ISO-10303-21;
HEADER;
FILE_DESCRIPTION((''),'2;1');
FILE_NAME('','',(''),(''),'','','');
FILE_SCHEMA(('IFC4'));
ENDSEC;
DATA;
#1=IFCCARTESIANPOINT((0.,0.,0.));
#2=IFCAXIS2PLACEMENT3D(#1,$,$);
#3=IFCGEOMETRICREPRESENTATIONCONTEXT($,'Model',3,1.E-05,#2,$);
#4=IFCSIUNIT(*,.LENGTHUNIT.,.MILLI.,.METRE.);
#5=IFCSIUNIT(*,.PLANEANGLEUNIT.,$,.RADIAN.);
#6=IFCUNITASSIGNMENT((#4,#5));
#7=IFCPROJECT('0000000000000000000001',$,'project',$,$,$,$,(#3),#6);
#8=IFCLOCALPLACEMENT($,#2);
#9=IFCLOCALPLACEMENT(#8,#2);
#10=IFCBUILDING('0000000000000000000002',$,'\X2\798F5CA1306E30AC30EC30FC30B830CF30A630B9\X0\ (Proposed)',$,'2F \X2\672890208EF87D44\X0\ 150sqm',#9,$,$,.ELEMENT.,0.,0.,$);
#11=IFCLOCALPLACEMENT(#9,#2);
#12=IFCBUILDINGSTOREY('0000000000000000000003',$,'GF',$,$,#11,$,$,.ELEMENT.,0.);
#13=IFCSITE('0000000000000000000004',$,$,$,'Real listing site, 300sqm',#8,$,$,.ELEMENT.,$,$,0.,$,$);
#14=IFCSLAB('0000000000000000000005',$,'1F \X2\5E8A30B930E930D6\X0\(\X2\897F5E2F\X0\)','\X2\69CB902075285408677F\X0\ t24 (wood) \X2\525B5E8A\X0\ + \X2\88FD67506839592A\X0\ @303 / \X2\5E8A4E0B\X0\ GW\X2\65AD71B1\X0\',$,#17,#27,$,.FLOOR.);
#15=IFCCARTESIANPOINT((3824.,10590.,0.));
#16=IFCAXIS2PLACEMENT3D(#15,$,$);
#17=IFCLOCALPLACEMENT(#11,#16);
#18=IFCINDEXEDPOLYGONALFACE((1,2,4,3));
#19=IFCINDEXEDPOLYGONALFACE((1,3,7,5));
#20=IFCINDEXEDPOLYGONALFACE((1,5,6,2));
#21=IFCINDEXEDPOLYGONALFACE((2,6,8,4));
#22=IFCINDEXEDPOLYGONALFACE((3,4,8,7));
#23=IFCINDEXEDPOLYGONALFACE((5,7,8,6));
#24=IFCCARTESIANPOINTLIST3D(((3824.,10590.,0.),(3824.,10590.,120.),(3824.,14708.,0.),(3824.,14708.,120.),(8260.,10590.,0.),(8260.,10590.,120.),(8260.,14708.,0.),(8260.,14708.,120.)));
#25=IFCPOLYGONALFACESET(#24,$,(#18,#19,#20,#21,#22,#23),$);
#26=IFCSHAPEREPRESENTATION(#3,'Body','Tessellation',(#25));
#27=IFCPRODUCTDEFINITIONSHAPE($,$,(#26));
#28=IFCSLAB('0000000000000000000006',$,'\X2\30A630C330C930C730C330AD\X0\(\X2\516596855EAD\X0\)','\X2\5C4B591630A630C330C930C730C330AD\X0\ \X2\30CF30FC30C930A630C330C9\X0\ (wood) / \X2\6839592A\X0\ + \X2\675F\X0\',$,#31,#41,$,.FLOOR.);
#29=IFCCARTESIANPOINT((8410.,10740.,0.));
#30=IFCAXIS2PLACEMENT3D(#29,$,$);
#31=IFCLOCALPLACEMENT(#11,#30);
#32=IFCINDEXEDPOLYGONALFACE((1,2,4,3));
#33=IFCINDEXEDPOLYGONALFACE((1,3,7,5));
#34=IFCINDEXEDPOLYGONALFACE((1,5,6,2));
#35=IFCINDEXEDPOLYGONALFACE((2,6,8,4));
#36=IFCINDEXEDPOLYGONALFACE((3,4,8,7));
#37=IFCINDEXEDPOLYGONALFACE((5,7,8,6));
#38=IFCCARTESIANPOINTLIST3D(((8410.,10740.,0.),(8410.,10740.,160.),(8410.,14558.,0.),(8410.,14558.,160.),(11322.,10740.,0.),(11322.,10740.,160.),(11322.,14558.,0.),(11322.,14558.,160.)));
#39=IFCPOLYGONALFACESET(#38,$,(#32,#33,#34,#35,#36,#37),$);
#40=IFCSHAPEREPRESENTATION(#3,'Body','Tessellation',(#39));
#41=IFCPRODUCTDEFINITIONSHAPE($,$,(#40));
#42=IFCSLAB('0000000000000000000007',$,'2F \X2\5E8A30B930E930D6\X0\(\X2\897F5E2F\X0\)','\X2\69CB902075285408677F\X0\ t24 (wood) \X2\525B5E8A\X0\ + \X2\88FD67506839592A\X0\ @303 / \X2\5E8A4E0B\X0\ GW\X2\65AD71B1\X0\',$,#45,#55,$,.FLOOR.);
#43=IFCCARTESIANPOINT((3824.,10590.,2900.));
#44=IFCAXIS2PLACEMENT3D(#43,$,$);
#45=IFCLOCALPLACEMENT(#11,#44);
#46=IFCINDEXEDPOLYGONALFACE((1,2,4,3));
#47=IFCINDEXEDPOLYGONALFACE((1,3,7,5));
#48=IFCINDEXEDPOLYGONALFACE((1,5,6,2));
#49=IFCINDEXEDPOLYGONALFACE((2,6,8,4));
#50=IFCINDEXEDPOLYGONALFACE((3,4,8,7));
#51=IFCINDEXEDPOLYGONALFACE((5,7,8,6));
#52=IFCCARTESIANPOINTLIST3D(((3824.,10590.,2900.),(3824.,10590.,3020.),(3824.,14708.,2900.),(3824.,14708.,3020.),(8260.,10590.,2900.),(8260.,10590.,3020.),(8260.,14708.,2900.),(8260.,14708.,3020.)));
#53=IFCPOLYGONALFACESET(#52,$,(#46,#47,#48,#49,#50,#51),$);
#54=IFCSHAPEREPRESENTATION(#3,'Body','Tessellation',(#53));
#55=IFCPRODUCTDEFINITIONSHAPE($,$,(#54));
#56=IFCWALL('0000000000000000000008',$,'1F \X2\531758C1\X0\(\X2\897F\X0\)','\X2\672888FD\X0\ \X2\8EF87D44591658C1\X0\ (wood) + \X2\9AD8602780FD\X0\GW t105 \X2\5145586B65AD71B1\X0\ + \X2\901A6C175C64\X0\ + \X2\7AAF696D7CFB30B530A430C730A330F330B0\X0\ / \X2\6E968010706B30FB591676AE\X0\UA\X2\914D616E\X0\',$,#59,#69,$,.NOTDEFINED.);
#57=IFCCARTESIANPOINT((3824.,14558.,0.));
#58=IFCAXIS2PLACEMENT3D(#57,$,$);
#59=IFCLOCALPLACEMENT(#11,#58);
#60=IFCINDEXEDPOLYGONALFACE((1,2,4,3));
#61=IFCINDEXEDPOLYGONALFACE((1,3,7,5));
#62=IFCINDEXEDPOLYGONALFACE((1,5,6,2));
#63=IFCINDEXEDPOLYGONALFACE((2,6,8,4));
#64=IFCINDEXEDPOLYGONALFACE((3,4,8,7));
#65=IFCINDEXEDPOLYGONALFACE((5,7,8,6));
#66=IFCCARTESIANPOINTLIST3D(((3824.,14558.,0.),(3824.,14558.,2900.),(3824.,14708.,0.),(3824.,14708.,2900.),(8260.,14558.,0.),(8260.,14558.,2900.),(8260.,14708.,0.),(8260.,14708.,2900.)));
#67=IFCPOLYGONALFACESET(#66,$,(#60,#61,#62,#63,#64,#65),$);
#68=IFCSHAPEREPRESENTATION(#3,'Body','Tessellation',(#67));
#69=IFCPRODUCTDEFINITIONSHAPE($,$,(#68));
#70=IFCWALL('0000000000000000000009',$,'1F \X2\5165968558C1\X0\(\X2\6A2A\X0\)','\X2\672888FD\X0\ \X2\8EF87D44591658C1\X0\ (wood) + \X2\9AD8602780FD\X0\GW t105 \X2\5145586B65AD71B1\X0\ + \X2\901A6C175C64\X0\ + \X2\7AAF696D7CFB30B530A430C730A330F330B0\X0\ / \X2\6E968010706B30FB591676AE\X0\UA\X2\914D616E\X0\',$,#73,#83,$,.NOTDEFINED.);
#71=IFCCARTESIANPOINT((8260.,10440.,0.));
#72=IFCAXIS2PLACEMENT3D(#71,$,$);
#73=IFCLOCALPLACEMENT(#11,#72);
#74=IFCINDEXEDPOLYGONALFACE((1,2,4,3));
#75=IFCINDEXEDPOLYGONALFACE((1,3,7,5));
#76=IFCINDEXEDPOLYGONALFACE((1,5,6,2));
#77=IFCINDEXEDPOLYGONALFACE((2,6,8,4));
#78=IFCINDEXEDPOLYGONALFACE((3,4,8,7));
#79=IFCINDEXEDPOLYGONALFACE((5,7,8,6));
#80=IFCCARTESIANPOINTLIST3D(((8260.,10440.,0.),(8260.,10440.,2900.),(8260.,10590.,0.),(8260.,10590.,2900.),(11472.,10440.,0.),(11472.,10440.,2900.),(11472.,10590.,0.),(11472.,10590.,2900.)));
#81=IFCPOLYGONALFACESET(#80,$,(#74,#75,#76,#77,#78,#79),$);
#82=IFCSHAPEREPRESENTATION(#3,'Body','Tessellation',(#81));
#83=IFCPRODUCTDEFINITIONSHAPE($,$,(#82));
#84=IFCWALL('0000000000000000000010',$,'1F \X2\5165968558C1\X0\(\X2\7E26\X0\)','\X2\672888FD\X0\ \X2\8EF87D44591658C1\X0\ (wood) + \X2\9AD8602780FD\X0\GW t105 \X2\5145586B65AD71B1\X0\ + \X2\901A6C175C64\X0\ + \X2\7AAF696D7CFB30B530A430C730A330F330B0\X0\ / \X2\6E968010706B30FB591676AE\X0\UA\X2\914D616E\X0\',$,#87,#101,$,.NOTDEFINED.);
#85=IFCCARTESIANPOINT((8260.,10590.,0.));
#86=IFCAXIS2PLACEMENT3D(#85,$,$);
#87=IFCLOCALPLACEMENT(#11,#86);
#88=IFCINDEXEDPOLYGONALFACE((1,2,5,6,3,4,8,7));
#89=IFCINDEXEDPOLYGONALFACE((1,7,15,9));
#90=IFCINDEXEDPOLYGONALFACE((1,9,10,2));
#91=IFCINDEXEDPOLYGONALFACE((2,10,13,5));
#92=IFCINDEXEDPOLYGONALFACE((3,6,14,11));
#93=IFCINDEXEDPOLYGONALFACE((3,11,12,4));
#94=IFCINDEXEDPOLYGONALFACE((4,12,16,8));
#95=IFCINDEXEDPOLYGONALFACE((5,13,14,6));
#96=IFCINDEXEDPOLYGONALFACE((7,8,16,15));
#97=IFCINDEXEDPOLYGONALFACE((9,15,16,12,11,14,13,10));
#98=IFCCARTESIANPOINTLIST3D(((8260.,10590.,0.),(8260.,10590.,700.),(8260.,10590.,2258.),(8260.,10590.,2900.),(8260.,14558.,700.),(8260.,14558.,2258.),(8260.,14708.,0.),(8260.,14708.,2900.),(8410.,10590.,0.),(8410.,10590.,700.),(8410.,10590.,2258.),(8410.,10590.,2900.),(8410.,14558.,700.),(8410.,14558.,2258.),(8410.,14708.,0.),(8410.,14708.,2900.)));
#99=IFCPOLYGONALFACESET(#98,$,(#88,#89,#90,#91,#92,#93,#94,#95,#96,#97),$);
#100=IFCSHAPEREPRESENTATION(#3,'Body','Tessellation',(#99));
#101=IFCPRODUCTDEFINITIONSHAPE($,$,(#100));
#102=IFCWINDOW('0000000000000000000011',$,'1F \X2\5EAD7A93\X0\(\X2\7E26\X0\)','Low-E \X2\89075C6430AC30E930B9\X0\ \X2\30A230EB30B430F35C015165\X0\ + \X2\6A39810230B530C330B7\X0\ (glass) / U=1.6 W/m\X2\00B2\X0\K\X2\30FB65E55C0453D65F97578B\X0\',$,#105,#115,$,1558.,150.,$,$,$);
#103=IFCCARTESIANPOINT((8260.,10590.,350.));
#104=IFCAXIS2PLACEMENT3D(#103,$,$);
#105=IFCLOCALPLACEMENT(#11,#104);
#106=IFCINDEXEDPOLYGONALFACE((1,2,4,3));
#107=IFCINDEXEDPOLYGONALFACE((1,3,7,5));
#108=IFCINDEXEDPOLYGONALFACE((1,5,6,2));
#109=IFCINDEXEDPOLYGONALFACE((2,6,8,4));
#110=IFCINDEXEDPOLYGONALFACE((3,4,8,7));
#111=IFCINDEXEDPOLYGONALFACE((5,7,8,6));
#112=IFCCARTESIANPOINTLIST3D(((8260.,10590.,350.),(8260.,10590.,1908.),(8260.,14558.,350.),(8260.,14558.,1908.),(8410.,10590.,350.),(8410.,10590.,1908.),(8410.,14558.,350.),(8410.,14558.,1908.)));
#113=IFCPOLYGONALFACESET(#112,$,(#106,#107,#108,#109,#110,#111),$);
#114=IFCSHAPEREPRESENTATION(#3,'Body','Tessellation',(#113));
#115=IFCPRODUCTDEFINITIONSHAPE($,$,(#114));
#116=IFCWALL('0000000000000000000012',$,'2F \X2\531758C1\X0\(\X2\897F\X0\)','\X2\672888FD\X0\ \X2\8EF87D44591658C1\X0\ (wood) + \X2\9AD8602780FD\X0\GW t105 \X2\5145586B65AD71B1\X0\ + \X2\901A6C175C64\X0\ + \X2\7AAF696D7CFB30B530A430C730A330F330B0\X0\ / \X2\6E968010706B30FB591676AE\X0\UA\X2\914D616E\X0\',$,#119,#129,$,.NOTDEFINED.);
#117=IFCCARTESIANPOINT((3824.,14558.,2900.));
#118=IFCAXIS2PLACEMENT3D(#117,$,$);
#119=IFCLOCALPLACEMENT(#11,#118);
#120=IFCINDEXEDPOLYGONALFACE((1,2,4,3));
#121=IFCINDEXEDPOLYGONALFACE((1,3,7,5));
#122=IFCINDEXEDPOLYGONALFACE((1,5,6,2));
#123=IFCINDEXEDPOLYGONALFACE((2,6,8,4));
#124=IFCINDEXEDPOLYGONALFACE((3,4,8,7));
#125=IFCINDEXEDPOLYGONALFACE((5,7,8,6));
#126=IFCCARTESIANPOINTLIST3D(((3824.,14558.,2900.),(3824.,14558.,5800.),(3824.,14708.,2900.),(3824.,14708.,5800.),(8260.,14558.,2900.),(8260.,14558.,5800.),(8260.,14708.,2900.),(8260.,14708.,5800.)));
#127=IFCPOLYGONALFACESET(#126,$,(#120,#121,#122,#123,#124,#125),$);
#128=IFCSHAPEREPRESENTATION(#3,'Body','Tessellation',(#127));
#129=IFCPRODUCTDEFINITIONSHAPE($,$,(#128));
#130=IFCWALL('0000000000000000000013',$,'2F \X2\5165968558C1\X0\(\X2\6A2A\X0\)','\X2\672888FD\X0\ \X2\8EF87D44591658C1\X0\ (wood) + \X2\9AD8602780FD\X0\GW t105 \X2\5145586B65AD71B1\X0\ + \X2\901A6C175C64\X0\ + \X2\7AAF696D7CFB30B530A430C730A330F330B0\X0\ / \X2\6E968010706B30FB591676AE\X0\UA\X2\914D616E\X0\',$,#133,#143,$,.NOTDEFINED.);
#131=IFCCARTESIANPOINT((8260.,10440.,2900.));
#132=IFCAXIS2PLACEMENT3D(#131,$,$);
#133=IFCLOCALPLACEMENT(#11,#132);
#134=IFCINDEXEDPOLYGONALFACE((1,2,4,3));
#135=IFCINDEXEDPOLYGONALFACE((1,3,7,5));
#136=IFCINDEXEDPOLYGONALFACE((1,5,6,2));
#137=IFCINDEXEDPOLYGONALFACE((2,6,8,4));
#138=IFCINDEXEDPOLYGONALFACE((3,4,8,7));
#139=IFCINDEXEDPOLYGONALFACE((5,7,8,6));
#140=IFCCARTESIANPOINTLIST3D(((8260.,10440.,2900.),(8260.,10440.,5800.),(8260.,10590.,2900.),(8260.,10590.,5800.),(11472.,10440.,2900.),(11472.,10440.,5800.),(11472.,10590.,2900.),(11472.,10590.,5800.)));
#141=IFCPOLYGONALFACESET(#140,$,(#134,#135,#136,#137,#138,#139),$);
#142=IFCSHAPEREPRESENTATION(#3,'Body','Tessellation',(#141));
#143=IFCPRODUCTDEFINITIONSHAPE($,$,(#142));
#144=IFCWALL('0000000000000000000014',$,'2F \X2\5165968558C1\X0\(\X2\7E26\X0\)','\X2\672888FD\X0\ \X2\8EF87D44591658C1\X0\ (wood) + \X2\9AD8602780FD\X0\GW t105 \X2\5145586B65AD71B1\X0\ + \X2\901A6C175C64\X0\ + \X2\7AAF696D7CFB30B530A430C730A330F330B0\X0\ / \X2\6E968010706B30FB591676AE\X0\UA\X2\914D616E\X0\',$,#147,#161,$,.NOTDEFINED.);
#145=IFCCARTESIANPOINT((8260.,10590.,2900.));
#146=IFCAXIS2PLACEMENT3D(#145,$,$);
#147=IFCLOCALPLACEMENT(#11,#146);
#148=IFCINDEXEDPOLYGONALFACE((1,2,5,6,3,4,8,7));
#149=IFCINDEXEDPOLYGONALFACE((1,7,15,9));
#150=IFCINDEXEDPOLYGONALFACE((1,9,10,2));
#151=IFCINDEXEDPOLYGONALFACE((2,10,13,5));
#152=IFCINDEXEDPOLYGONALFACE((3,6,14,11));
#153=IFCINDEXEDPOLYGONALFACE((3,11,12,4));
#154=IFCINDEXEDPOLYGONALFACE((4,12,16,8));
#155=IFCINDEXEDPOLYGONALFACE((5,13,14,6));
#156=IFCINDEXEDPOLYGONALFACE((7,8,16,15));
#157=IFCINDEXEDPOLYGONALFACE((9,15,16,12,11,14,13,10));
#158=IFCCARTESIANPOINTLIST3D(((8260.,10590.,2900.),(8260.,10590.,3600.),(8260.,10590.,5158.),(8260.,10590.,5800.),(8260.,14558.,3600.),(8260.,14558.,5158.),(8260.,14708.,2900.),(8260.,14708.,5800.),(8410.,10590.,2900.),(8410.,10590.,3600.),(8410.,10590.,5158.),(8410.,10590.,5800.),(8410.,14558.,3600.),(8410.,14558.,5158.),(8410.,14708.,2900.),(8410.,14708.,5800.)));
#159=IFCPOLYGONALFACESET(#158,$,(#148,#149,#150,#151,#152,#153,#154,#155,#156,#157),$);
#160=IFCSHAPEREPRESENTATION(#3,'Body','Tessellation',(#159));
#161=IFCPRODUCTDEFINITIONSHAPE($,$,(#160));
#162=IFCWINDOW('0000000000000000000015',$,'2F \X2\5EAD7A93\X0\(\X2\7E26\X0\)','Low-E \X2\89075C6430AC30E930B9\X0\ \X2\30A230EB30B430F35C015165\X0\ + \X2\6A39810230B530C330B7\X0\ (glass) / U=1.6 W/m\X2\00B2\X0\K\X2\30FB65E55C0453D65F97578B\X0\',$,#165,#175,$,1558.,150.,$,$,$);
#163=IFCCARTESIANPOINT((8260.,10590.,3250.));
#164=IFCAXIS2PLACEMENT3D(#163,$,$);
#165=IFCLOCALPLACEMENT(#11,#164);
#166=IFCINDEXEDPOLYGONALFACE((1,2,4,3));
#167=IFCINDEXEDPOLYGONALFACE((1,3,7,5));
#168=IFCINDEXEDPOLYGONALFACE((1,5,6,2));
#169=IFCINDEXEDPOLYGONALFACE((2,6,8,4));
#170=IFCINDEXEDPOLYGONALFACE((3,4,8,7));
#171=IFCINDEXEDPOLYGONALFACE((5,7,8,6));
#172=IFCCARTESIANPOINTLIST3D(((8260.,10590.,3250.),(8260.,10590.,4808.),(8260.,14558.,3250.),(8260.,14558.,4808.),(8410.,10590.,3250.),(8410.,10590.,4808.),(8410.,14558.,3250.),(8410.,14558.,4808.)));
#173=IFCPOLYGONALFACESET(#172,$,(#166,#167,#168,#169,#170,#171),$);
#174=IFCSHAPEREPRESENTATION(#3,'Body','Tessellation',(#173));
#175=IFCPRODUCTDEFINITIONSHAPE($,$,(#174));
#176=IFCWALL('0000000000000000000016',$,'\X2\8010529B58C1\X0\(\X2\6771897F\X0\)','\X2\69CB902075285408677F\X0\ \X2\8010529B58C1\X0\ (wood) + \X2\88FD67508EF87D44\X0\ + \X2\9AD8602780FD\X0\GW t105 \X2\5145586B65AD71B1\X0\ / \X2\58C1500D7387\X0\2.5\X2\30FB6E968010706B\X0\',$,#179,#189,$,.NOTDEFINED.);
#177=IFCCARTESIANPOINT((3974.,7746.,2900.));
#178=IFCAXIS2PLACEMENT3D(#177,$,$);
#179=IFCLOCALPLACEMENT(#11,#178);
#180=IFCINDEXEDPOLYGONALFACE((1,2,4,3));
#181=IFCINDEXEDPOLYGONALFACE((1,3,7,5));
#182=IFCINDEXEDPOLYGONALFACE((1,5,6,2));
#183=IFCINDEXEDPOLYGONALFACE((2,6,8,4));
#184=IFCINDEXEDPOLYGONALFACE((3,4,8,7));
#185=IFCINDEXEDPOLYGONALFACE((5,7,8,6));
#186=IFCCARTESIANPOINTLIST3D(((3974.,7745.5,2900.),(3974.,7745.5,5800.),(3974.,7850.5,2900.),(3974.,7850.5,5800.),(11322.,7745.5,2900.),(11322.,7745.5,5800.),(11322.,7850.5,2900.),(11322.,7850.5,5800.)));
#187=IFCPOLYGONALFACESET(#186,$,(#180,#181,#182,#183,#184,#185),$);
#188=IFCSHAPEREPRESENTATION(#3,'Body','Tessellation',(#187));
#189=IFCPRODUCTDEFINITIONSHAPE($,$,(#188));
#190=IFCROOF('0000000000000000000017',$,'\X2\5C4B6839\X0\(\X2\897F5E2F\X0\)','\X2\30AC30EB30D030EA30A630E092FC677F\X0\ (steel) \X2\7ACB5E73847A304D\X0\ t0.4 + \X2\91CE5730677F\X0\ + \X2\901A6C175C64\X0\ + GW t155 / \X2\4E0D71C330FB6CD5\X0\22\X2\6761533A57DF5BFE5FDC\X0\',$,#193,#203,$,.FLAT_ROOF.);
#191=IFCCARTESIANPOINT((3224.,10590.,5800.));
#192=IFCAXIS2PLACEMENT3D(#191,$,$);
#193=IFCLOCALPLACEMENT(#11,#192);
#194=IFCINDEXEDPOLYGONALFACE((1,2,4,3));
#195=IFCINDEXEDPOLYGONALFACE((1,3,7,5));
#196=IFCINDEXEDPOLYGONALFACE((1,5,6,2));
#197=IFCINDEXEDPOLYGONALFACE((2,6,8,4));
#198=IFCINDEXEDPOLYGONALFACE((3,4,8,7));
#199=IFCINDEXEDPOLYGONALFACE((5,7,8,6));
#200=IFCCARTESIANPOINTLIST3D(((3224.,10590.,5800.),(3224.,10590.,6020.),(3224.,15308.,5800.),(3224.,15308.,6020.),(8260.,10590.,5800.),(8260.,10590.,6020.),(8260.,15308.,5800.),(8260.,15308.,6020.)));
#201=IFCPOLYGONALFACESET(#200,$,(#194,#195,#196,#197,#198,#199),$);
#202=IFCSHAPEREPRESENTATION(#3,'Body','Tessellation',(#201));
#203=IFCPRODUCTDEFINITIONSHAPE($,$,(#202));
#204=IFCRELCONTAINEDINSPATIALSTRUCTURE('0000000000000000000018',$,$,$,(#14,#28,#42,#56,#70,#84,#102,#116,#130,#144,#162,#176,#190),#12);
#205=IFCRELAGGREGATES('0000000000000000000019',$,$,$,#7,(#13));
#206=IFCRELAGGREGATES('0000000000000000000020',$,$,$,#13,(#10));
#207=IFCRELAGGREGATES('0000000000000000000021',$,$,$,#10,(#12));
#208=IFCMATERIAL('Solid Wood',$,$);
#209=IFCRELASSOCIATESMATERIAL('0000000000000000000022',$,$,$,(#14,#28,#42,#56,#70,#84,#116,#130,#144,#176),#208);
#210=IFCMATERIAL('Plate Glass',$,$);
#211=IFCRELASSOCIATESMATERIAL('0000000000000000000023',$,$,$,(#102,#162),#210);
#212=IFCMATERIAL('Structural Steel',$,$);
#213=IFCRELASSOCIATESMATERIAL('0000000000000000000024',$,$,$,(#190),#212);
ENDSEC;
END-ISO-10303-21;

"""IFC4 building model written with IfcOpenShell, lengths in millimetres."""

from ifc_helpers import new_model, si_unit, frame, frame_2d, origin, place, context, project, spatial, rectangle, extrude, material, element, fill, save


model = new_model("IFC4")

# Units and contexts
model_context = context("Model", 3, precision=1e-05, world=origin())
ifc_project = project(units=[si_unit("LENGTHUNIT", "METRE", prefix="MILLI"), si_unit("PLANEANGLEUNIT", "RADIAN")], contexts=[model_context])

# Site, building, storey
site_placement = place(None, origin())
site = spatial("IfcSite", under=ifc_project, at=site_placement, ObjectType="Real listing site, 300sqm", CompositionType="ELEMENT", RefElevation=0.0)
building_placement = place(site_placement, origin())
building = spatial("IfcBuilding", under=site, at=building_placement, Name="福岡のガレージハウス (Proposed)", ObjectType="2F 木造軸組 150sqm", CompositionType="ELEMENT", ElevationOfRefHeight=0.0, ElevationOfTerrain=0.0)
storey_placement = place(building_placement, origin())
storey = spatial("IfcBuildingStorey", under=building, at=storey_placement, Name="GF", CompositionType="ELEMENT", Elevation=0.0)

# Slabs
ifc_material_1 = material(Name="Solid Wood")
slab_1_placement = place(storey_placement, frame((3824.0, 10590.0, 0.0)))
element("IfcSlab", 1, at=slab_1_placement, inside=storey, material=ifc_material_1, Name="1F 床スラブ(西帯)", Description="構造用合板 t24 (wood) 剛床 + 製材根太 @303 / 床下 GW断熱", PredefinedType="FLOOR", context=model_context, shape_type="SweptSolid", body=[
    extrude(rectangle(XDim=4436.0, YDim=4118.0, at=frame_2d((2218.0, 2059.0))), frame((3824.0, 10590.0, 0.0)), (0.0, 0.0, 1.0), 120.0),
])
slab_2_placement = place(storey_placement, frame((8410.0, 10740.0, 0.0)))
element("IfcSlab", 2, at=slab_2_placement, inside=storey, material=ifc_material_1, Name="ウッドデッキ(入隅庭)", Description="屋外ウッドデッキ ハードウッド (wood) / 根太 + 束", PredefinedType="FLOOR", context=model_context, shape_type="SweptSolid", body=[
    extrude(rectangle(XDim=2912.0, YDim=3818.0, at=frame_2d((1456.0, 1909.0))), frame((8410.0, 10740.0, 0.0)), (0.0, 0.0, 1.0), 160.0),
])
slab_3_placement = place(storey_placement, frame((3824.0, 10590.0, 2900.0)))
element("IfcSlab", 3, at=slab_3_placement, inside=storey, material=ifc_material_1, Name="2F 床スラブ(西帯)", Description="構造用合板 t24 (wood) 剛床 + 製材根太 @303 / 床下 GW断熱", PredefinedType="FLOOR", context=model_context, shape_type="SweptSolid", body=[
    extrude(rectangle(XDim=4436.0, YDim=4118.0, at=frame_2d((2218.0, 2059.0))), frame((3824.0, 10590.0, 2900.0)), (0.0, 0.0, 1.0), 120.0),
])

# Walls
wall_1_placement = place(storey_placement, frame((3824.0, 14558.0, 0.0)))
element("IfcWall", 4, at=wall_1_placement, inside=storey, material=ifc_material_1, Name="1F 北壁(西)", Description="木製 軸組外壁 (wood) + 高性能GW t105 充填断熱 + 通気層 + 窯業系サイディング / 準耐火・外皮UA配慮", PredefinedType="NOTDEFINED", context=model_context, shape_type="SweptSolid", body=[
    extrude(rectangle(XDim=4436.0, YDim=150.0, at=frame_2d((2218.0, 75.0))), frame((3824.0, 14558.0, 0.0)), (0.0, 0.0, 1.0), 2900.0),
])
wall_2_placement = place(storey_placement, frame((8260.0, 10440.0, 0.0)))
element("IfcWall", 5, at=wall_2_placement, inside=storey, material=ifc_material_1, Name="1F 入隅壁(横)", Description="木製 軸組外壁 (wood) + 高性能GW t105 充填断熱 + 通気層 + 窯業系サイディング / 準耐火・外皮UA配慮", PredefinedType="NOTDEFINED", context=model_context, shape_type="SweptSolid", body=[
    extrude(rectangle(XDim=3212.0, YDim=150.0, at=frame_2d((1606.0, 75.0))), frame((8260.0, 10440.0, 0.0)), (0.0, 0.0, 1.0), 2900.0),
])

# Wall, opening, window
wall_3_placement = place(storey_placement, frame((8260.0, 10590.0, 0.0)))
wall_3 = element("IfcWall", 6, at=wall_3_placement, inside=storey, material=ifc_material_1, Name="1F 入隅壁(縦)", Description="木製 軸組外壁 (wood) + 高性能GW t105 充填断熱 + 通気層 + 窯業系サイディング / 準耐火・外皮UA配慮", PredefinedType="NOTDEFINED", context=model_context, shape_type="SweptSolid", body=[
    extrude(rectangle(XDim=150.0, YDim=4118.0, at=frame_2d((75.0, 2059.0))), frame((8260.0, 10590.0, 0.0)), (0.0, 0.0, 1.0), 2900.0),
])
opening_1_placement = place(storey_placement, frame((8260.0, 10590.0, 350.0)))
opening_1 = element("IfcOpeningElement", 7, at=opening_1_placement, cuts=wall_3, PredefinedType="NOTDEFINED", context=model_context, shape_type="SweptSolid", body=[
    extrude(rectangle(XDim=150.0, YDim=3968.0, at=frame_2d((75.0, 1984.0))), frame((8260.0, 10590.0, 350.0)), (0.0, 0.0, 1.0), 1558.0),
])
ifc_material_2 = material(Name="Plate Glass")
window_1_placement = place(storey_placement, frame((8260.0, 10590.0, 350.0)))
window_1 = element("IfcWindow", 8, at=window_1_placement, inside=storey, material=ifc_material_2, Name="1F 庭窓(縦)", Description="Low-E 複層ガラス アルゴン封入 + 樹脂サッシ (glass) / U=1.6 W/m²K・日射取得型", OverallHeight=1558.0, OverallWidth=150.0, context=model_context, shape_type="SweptSolid", body=[
    extrude(rectangle(XDim=150.0, YDim=3968.0, at=frame_2d((75.0, 1984.0))), frame((8260.0, 10590.0, 350.0)), (0.0, 0.0, 1.0), 1558.0),
])
fill(opening_1, window_1)

# Walls
wall_4_placement = place(storey_placement, frame((3824.0, 14558.0, 2900.0)))
element("IfcWall", 9, at=wall_4_placement, inside=storey, material=ifc_material_1, Name="2F 北壁(西)", Description="木製 軸組外壁 (wood) + 高性能GW t105 充填断熱 + 通気層 + 窯業系サイディング / 準耐火・外皮UA配慮", PredefinedType="NOTDEFINED", context=model_context, shape_type="SweptSolid", body=[
    extrude(rectangle(XDim=4436.0, YDim=150.0, at=frame_2d((2218.0, 75.0))), frame((3824.0, 14558.0, 2900.0)), (0.0, 0.0, 1.0), 2900.0),
])
wall_5_placement = place(storey_placement, frame((8260.0, 10440.0, 2900.0)))
element("IfcWall", 10, at=wall_5_placement, inside=storey, material=ifc_material_1, Name="2F 入隅壁(横)", Description="木製 軸組外壁 (wood) + 高性能GW t105 充填断熱 + 通気層 + 窯業系サイディング / 準耐火・外皮UA配慮", PredefinedType="NOTDEFINED", context=model_context, shape_type="SweptSolid", body=[
    extrude(rectangle(XDim=3212.0, YDim=150.0, at=frame_2d((1606.0, 75.0))), frame((8260.0, 10440.0, 2900.0)), (0.0, 0.0, 1.0), 2900.0),
])

# Wall, opening, window
wall_6_placement = place(storey_placement, frame((8260.0, 10590.0, 2900.0)))
wall_6 = element("IfcWall", 11, at=wall_6_placement, inside=storey, material=ifc_material_1, Name="2F 入隅壁(縦)", Description="木製 軸組外壁 (wood) + 高性能GW t105 充填断熱 + 通気層 + 窯業系サイディング / 準耐火・外皮UA配慮", PredefinedType="NOTDEFINED", context=model_context, shape_type="SweptSolid", body=[
    extrude(rectangle(XDim=150.0, YDim=4118.0, at=frame_2d((75.0, 2059.0))), frame((8260.0, 10590.0, 2900.0)), (0.0, 0.0, 1.0), 2900.0),
])
opening_2_placement = place(storey_placement, frame((8260.0, 10590.0, 3250.0)))
opening_2 = element("IfcOpeningElement", 12, at=opening_2_placement, cuts=wall_6, PredefinedType="NOTDEFINED", context=model_context, shape_type="SweptSolid", body=[
    extrude(rectangle(XDim=150.0, YDim=3968.0, at=frame_2d((75.0, 1984.0))), frame((8260.0, 10590.0, 3250.0)), (0.0, 0.0, 1.0), 1558.0),
])
window_2_placement = place(storey_placement, frame((8260.0, 10590.0, 3250.0)))
window_2 = element("IfcWindow", 13, at=window_2_placement, inside=storey, material=ifc_material_2, Name="2F 庭窓(縦)", Description="Low-E 複層ガラス アルゴン封入 + 樹脂サッシ (glass) / U=1.6 W/m²K・日射取得型", OverallHeight=1558.0, OverallWidth=150.0, context=model_context, shape_type="SweptSolid", body=[
    extrude(rectangle(XDim=150.0, YDim=3968.0, at=frame_2d((75.0, 1984.0))), frame((8260.0, 10590.0, 3250.0)), (0.0, 0.0, 1.0), 1558.0),
])
fill(opening_2, window_2)

# Wall
wall_7_placement = place(storey_placement, frame((3974.0, 7746.0, 2900.0)))
element("IfcWall", 14, at=wall_7_placement, inside=storey, material=ifc_material_1, Name="耐力壁(東西)", Description="構造用合板 耐力壁 (wood) + 製材軸組 + 高性能GW t105 充填断熱 / 壁倍率2.5・準耐火", PredefinedType="NOTDEFINED", context=model_context, shape_type="SweptSolid", body=[
    extrude(rectangle(XDim=7348.0, YDim=105.0, at=frame_2d((3674.0, 52.0))), frame((3974.0, 7746.0, 2900.0)), (0.0, 0.0, 1.0), 2900.0),
])

# Roof
ifc_material_3 = material(Name="Structural Steel")
for number, where, name in (
    (15, (3224.0, 10590.0, 5800.0), "屋根(西帯)"),
):
    element("IfcRoof", number, at=place(storey_placement, frame(where)), inside=storey, material=ifc_material_3, Name=name, Description="ガルバリウム鋼板 (steel) 立平葺き t0.4 + 野地板 + 通気層 + GW t155 / 不燃・法22条区域対応", PredefinedType="FLAT_ROOF", context=model_context, shape_type="SweptSolid", body=[
        extrude(rectangle(XDim=5036.0, YDim=4718.0, at=frame_2d((2518.0, 2359.0))), frame((3224.0, 10590.0, 5800.0)), (0.0, 0.0, 1.0), 220.0),
    ])

save(model, "model.ifc")
